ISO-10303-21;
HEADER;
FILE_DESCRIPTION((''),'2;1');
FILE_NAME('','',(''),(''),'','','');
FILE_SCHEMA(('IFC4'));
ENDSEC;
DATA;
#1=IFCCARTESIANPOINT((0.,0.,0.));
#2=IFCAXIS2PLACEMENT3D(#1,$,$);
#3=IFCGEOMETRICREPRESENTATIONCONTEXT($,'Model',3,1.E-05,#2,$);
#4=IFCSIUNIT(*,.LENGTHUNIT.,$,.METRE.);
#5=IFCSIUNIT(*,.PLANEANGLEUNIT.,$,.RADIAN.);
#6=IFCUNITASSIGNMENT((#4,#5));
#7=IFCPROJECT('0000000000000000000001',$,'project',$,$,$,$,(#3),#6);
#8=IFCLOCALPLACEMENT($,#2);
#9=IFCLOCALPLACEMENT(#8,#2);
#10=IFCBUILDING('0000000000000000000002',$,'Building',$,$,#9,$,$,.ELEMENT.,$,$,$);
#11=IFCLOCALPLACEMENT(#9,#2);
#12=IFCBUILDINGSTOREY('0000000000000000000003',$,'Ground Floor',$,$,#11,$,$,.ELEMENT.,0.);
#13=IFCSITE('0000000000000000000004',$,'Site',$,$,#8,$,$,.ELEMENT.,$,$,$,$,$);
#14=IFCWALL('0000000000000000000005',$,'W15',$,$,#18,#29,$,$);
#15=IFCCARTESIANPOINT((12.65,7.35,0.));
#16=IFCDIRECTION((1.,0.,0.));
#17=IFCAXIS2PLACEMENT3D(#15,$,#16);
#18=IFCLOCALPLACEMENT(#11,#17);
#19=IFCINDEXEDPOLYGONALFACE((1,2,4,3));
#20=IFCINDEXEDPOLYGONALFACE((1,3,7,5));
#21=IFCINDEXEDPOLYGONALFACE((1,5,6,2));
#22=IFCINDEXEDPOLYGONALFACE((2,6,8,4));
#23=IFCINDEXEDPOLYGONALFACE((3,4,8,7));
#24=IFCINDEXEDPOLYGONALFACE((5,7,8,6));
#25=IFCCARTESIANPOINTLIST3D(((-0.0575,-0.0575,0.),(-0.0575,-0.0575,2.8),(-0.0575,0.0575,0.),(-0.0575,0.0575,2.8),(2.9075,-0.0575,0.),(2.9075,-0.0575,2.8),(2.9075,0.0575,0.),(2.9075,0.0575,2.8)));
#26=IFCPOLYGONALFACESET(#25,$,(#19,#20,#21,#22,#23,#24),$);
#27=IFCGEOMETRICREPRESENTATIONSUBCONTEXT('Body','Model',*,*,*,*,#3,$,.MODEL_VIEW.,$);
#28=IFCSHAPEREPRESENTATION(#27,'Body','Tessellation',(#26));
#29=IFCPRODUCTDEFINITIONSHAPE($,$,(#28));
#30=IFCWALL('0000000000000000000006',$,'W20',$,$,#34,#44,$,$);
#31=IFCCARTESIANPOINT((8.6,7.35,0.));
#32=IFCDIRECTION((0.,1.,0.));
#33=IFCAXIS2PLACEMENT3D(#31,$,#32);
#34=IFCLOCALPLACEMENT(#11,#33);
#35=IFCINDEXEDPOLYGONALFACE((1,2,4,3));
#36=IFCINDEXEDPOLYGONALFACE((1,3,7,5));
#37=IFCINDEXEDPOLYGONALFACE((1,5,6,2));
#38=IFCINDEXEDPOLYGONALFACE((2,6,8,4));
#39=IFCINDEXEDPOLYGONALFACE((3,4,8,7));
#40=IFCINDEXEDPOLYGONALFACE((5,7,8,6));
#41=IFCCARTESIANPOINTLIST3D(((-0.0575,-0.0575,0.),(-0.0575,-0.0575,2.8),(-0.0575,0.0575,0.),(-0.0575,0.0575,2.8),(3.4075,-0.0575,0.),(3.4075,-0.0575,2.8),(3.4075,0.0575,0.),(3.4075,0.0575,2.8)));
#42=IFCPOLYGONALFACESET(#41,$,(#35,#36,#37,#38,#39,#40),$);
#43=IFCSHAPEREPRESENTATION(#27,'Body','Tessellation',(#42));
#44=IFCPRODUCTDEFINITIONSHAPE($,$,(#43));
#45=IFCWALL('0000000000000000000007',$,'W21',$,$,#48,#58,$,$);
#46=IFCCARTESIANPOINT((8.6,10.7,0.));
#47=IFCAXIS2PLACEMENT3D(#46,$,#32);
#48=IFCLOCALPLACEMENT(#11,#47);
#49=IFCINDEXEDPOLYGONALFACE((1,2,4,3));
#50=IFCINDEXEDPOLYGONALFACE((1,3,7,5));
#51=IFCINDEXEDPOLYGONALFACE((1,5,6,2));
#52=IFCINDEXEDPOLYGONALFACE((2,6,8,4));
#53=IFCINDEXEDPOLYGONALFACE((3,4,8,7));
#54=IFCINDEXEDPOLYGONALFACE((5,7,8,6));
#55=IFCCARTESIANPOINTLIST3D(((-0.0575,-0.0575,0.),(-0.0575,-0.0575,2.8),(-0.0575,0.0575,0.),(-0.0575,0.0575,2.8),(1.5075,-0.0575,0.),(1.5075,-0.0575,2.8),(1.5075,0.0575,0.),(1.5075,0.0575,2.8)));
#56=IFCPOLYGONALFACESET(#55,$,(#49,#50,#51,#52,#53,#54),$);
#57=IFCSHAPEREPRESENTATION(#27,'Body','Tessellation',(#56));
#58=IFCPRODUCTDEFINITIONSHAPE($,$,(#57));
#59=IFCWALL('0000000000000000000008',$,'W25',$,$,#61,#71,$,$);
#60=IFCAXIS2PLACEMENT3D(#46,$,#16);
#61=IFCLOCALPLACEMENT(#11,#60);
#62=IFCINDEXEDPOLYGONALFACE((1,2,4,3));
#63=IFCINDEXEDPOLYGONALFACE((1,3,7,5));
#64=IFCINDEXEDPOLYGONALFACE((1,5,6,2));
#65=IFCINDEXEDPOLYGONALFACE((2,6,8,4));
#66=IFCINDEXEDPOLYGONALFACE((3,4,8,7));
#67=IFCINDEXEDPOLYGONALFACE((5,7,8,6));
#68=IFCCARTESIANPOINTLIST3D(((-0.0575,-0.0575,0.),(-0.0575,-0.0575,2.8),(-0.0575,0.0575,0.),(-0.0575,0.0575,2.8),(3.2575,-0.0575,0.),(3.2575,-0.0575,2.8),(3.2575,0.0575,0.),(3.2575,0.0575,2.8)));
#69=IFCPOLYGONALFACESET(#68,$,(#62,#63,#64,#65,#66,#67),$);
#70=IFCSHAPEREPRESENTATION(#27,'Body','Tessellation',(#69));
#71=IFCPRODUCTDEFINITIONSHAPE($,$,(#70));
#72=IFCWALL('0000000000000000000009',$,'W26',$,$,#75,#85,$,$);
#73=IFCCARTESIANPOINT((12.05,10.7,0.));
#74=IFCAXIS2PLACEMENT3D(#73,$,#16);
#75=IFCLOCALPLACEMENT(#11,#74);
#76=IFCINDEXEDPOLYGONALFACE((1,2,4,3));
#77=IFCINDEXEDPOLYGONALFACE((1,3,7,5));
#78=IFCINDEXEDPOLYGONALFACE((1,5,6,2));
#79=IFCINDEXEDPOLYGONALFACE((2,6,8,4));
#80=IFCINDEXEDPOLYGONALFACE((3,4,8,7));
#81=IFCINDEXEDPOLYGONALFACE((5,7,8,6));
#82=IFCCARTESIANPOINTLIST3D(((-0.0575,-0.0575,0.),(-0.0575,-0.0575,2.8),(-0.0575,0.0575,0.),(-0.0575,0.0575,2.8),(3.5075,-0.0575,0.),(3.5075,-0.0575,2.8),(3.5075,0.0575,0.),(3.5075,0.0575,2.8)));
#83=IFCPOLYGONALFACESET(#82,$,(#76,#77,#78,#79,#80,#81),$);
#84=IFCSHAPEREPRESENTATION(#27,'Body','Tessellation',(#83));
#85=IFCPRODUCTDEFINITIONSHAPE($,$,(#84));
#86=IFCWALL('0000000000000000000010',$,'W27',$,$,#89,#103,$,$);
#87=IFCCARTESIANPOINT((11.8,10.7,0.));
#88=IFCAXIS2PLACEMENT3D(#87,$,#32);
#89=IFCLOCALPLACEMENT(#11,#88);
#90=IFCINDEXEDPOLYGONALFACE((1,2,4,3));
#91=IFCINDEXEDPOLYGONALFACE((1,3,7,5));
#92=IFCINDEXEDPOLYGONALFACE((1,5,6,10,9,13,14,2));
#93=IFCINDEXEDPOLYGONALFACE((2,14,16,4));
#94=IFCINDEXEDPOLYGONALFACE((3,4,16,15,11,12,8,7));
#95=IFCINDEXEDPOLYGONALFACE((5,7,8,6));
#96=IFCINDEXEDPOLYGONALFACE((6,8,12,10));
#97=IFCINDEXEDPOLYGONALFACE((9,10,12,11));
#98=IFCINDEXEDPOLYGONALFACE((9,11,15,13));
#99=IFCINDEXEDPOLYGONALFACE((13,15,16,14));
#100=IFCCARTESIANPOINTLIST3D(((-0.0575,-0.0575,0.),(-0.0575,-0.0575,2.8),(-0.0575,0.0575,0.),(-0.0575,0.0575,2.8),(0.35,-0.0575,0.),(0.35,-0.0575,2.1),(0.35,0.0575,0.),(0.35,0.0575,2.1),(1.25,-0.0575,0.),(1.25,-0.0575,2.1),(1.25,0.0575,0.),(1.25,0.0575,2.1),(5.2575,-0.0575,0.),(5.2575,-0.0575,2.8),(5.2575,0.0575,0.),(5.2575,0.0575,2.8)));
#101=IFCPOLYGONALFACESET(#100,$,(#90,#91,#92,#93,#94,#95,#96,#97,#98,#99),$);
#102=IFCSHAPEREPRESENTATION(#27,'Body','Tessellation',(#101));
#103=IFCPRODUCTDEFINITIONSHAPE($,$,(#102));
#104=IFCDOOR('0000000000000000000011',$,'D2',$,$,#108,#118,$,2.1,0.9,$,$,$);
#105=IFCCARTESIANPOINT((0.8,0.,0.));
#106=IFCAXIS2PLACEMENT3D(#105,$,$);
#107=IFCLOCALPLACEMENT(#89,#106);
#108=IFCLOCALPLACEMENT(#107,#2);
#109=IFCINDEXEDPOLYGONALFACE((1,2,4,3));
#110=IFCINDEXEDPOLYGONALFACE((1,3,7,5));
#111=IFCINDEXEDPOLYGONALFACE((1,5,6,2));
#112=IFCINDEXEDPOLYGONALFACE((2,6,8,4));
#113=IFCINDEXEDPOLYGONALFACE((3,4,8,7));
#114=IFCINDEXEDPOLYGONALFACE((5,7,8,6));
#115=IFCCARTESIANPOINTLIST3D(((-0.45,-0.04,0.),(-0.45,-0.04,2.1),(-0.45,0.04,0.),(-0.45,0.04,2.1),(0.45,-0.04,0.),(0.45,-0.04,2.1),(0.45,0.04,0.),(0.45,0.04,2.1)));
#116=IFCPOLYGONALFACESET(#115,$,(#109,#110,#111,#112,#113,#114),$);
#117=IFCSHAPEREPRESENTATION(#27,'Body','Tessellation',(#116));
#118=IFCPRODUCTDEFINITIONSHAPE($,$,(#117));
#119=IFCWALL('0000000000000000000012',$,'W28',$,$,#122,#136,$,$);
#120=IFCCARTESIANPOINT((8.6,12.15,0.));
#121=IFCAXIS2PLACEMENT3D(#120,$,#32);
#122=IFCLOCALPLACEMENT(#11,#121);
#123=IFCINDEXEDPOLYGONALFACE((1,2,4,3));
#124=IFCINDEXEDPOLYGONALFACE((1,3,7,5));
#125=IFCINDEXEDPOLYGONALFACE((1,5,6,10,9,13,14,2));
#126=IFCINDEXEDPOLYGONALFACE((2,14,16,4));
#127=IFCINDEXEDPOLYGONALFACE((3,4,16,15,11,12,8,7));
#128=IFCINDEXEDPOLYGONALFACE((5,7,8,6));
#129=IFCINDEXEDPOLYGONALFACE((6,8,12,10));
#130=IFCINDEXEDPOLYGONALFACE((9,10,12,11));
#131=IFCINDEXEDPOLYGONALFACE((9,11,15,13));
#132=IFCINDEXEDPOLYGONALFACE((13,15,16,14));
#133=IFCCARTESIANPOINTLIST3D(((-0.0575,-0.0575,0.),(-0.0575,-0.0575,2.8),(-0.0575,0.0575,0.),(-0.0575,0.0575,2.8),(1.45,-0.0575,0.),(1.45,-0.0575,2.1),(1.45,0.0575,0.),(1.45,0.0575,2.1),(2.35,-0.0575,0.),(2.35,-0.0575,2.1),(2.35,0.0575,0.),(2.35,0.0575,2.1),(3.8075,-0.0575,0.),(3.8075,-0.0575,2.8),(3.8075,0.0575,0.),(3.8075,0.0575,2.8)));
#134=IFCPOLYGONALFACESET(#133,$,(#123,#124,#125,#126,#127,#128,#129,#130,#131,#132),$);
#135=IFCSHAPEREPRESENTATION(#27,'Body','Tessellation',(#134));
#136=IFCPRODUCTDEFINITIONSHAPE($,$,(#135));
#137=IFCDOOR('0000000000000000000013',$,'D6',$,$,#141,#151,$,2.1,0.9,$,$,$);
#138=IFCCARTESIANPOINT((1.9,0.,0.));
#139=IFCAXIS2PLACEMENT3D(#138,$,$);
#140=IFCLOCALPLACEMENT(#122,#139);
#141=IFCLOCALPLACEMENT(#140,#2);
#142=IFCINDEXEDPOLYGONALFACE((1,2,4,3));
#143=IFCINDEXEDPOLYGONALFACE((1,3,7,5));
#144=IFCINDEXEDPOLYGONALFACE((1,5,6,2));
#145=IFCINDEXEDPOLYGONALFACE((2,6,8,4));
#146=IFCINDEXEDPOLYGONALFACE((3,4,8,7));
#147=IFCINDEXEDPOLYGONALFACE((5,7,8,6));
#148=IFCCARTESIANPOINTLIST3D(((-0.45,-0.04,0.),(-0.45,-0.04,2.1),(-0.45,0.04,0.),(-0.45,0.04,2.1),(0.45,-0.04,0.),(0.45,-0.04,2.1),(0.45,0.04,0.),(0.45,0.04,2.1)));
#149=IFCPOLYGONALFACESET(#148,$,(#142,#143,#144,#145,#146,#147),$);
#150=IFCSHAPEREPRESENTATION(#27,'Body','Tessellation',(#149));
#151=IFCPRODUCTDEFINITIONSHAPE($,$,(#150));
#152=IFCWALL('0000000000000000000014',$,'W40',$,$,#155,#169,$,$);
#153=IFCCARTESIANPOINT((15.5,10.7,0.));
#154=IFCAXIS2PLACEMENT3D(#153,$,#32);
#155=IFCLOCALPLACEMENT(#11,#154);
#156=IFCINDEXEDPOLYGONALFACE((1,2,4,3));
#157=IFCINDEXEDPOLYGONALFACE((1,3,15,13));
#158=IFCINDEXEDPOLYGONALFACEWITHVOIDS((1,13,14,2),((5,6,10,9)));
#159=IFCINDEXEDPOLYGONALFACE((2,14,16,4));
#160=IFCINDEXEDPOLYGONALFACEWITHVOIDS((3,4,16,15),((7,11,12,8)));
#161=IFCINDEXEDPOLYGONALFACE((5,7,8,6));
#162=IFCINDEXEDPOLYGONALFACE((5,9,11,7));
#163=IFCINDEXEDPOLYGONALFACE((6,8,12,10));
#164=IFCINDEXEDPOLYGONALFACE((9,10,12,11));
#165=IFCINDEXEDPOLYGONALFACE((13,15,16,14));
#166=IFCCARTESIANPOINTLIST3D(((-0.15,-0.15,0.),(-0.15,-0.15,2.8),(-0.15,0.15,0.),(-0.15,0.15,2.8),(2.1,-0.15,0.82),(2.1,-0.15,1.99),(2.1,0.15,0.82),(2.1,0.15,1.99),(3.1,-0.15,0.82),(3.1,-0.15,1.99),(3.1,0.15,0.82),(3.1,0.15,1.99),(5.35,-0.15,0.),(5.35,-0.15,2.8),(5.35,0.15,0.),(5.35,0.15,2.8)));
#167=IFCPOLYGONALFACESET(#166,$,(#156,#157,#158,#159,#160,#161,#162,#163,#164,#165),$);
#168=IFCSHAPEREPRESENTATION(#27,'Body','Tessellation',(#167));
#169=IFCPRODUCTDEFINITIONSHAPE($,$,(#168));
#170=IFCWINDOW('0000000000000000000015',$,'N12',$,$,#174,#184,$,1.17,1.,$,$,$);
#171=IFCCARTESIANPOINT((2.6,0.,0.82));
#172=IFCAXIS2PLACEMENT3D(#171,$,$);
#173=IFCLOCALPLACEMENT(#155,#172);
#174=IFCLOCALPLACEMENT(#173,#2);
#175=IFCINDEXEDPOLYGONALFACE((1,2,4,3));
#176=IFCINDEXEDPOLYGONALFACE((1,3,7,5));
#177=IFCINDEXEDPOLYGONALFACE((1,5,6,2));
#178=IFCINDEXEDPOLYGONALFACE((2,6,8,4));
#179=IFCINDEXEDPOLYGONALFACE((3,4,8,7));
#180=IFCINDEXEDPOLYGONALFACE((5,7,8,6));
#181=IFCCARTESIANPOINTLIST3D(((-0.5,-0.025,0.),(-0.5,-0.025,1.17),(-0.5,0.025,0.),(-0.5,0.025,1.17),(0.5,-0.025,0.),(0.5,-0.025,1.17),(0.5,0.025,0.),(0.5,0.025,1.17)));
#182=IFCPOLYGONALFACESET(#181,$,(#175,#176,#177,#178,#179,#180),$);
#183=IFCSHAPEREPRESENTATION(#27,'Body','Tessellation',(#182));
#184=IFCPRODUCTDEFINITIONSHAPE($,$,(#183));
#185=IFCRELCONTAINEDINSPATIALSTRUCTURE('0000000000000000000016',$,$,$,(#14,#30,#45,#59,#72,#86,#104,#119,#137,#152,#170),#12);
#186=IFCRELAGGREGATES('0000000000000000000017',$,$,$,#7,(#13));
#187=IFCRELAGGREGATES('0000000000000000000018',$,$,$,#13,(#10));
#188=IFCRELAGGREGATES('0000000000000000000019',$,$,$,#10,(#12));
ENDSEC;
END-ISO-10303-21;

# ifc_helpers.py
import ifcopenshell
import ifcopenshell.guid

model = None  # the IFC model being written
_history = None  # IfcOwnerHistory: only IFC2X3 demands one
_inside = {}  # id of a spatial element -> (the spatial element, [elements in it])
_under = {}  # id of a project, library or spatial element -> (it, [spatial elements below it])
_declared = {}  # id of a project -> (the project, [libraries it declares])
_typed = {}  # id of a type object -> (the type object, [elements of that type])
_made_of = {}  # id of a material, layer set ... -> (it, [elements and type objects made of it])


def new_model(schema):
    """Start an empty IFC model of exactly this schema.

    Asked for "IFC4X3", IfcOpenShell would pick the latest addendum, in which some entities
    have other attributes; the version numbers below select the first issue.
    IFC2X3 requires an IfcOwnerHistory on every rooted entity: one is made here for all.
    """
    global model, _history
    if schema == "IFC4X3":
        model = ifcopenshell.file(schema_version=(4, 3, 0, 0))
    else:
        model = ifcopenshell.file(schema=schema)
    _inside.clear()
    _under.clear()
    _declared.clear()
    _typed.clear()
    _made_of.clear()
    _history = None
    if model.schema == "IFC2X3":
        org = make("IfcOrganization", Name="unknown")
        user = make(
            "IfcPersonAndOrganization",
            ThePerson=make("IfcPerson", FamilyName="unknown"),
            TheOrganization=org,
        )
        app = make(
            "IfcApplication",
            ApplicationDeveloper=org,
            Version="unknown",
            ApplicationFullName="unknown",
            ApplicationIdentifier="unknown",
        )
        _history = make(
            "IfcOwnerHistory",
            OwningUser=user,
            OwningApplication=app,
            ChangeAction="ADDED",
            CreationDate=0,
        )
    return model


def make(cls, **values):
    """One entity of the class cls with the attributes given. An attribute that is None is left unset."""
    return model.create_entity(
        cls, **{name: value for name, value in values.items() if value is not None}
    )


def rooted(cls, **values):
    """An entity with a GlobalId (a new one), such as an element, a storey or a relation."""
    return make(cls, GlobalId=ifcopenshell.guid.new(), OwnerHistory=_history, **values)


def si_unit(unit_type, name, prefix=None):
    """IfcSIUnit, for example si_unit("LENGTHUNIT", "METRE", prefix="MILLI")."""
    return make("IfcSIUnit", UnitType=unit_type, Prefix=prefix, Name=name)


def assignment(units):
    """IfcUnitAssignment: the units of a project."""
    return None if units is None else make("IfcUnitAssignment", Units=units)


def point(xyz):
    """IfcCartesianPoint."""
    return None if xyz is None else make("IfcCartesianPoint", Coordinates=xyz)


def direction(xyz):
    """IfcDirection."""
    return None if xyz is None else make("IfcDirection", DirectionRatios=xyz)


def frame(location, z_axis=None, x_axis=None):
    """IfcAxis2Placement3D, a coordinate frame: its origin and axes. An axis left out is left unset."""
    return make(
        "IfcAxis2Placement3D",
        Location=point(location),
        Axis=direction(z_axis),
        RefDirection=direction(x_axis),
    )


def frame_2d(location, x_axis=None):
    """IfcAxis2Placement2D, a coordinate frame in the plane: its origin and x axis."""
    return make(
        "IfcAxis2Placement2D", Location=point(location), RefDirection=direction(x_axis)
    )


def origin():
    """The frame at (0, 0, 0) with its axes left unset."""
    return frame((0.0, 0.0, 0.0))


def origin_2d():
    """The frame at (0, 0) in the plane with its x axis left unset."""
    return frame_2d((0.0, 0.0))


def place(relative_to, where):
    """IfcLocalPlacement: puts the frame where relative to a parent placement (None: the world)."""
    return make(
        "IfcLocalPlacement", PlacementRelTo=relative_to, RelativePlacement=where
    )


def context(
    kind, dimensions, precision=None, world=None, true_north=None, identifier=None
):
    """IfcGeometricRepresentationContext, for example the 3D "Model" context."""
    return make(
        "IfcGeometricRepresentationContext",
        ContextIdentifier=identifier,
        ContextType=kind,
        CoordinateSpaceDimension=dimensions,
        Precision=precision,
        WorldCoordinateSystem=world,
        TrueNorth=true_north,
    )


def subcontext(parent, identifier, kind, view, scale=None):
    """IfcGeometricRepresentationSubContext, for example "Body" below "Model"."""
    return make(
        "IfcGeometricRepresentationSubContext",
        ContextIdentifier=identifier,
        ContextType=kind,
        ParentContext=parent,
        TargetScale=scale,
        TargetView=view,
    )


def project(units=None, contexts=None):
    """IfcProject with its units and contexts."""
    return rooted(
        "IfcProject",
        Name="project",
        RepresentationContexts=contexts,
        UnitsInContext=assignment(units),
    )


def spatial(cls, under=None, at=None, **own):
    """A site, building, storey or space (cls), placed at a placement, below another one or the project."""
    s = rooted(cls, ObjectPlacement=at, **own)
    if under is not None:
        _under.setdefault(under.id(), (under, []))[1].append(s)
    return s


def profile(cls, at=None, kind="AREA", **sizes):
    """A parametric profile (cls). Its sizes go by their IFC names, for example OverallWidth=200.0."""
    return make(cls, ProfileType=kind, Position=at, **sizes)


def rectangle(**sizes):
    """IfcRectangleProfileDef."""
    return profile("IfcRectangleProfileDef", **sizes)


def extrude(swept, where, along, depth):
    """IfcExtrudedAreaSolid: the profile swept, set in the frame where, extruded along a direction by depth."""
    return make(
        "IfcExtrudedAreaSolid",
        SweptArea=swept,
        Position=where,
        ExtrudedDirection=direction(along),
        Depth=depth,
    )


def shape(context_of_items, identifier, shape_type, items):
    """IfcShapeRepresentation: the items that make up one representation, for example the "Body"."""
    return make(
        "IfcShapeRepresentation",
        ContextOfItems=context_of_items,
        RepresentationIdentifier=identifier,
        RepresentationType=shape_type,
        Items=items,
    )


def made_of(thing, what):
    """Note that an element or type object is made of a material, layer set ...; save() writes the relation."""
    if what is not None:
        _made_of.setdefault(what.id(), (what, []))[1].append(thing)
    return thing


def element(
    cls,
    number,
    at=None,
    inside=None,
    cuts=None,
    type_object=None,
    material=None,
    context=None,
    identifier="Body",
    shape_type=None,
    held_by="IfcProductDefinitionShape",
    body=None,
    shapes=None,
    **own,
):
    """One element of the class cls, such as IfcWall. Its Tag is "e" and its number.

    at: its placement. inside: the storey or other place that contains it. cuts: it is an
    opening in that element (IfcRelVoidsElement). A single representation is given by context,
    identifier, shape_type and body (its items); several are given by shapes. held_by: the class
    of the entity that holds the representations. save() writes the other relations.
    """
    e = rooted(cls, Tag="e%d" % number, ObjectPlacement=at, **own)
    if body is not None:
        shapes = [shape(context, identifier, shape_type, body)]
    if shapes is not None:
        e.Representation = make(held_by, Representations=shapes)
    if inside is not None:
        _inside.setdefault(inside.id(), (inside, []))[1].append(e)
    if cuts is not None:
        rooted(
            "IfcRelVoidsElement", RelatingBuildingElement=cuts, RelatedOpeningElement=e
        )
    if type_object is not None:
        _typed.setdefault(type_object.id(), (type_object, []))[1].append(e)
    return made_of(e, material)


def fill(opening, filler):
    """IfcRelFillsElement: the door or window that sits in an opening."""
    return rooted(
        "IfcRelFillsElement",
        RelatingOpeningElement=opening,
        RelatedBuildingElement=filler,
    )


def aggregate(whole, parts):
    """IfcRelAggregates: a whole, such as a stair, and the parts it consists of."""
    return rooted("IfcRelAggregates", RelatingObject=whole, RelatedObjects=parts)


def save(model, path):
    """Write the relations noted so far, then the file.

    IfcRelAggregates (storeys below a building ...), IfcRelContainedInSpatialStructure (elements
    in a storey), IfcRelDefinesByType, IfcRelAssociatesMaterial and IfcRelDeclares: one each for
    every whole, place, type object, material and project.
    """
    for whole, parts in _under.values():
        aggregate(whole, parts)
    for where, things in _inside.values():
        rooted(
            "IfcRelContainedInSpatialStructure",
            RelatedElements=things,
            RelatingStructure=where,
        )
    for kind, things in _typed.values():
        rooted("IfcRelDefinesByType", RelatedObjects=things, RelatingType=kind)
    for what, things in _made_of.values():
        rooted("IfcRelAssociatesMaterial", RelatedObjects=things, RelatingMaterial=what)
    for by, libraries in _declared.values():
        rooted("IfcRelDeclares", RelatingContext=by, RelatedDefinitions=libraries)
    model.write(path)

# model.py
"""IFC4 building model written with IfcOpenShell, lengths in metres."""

from ifc_helpers import new_model, si_unit, frame, frame_2d, origin, origin_2d, place, context, subcontext, project, spatial, rectangle, extrude, element, fill, save


model = new_model("IFC4")

# Units and contexts
model_context = context("Model", 3, precision=1e-05, world=origin())
body_context = subcontext(model_context, "Body", "Model", "MODEL_VIEW")
ifc_project = project(units=[si_unit("LENGTHUNIT", "METRE"), si_unit("PLANEANGLEUNIT", "RADIAN")], contexts=[model_context])

# Site, building, storey
site_placement = place(None, origin())
site = spatial("IfcSite", under=ifc_project, at=site_placement, Name="Site", CompositionType="ELEMENT")
building_placement = place(site_placement, origin())
building = spatial("IfcBuilding", under=site, at=building_placement, Name="Building", CompositionType="ELEMENT")
storey_placement = place(building_placement, origin())
storey = spatial("IfcBuildingStorey", under=building, at=storey_placement, Name="Ground Floor", CompositionType="ELEMENT", Elevation=0.0)

# Walls
wall_1_placement = place(storey_placement, frame((12.65, 7.35, 0.0), x_axis=(1.0, 0.0, 0.0)))
element("IfcWall", 1, at=wall_1_placement, inside=storey, Name="W15", context=body_context, shape_type="SweptSolid", body=[
    extrude(rectangle(XDim=2.965, YDim=0.115, at=frame_2d((1.425, 0.0))), origin(), (0.0, 0.0, 1.0), 2.8),
])
wall_2_placement = place(storey_placement, frame((8.6, 7.35, 0.0), x_axis=(0.0, 1.0, 0.0)))
element("IfcWall", 2, at=wall_2_placement, inside=storey, Name="W20", context=body_context, shape_type="SweptSolid", body=[
    extrude(rectangle(XDim=3.465, YDim=0.115, at=frame_2d((1.675, 0.0))), origin(), (0.0, 0.0, 1.0), 2.8),
])
wall_3_placement = place(storey_placement, frame((8.6, 10.7, 0.0), x_axis=(0.0, 1.0, 0.0)))
element("IfcWall", 3, at=wall_3_placement, inside=storey, Name="W21", context=body_context, shape_type="SweptSolid", body=[
    extrude(rectangle(XDim=1.565, YDim=0.115, at=frame_2d((0.725, 0.0))), origin(), (0.0, 0.0, 1.0), 2.8),
])

# Walls
wall_4_placement = place(storey_placement, frame((8.6, 10.7, 0.0), x_axis=(1.0, 0.0, 0.0)))
element("IfcWall", 4, at=wall_4_placement, inside=storey, Name="W25", context=body_context, shape_type="SweptSolid", body=[
    extrude(rectangle(XDim=3.315, YDim=0.115, at=frame_2d((1.6, 0.0))), origin(), (0.0, 0.0, 1.0), 2.8),
])
wall_5_placement = place(storey_placement, frame((12.05, 10.7, 0.0), x_axis=(1.0, 0.0, 0.0)))
element("IfcWall", 5, at=wall_5_placement, inside=storey, Name="W26", context=body_context, shape_type="SweptSolid", body=[
    extrude(rectangle(XDim=3.565, YDim=0.115, at=frame_2d((1.725, 0.0))), origin(), (0.0, 0.0, 1.0), 2.8),
])

# Walls, openings, doors
wall_6_placement = place(storey_placement, frame((11.8, 10.7, 0.0), x_axis=(0.0, 1.0, 0.0)))
wall_6 = element("IfcWall", 6, at=wall_6_placement, inside=storey, Name="W27", context=body_context, shape_type="SweptSolid", body=[
    extrude(rectangle(XDim=5.315, YDim=0.115, at=frame_2d((2.6, 0.0))), origin(), (0.0, 0.0, 1.0), 2.8),
])
opening_1_placement = place(wall_6_placement, frame((0.8, 0.0, 0.0)))
opening_1 = element("IfcOpeningElement", 7, at=opening_1_placement, cuts=wall_6, context=body_context, shape_type="SweptSolid", body=[
    extrude(rectangle(XDim=0.9, YDim=0.215, at=origin_2d()), origin(), (0.0, 0.0, 1.0), 2.1),
])
door_1_placement = place(opening_1_placement, origin())
door_1 = element("IfcDoor", 8, at=door_1_placement, inside=storey, Name="D2", OverallHeight=2.1, OverallWidth=0.9, context=body_context, shape_type="SweptSolid", body=[
    extrude(rectangle(XDim=0.9, YDim=0.08, at=origin_2d()), origin(), (0.0, 0.0, 1.0), 2.1),
])
fill(opening_1, door_1)
wall_7_placement = place(storey_placement, frame((8.6, 12.15, 0.0), x_axis=(0.0, 1.0, 0.0)))
wall_7 = element("IfcWall", 9, at=wall_7_placement, inside=storey, Name="W28", context=body_context, shape_type="SweptSolid", body=[
    extrude(rectangle(XDim=3.865, YDim=0.115, at=frame_2d((1.875, 0.0))), origin(), (0.0, 0.0, 1.0), 2.8),
])
opening_2_placement = place(wall_7_placement, frame((1.9, 0.0, 0.0)))
opening_2 = element("IfcOpeningElement", 10, at=opening_2_placement, cuts=wall_7, context=body_context, shape_type="SweptSolid", body=[
    extrude(rectangle(XDim=0.9, YDim=0.215, at=origin_2d()), origin(), (0.0, 0.0, 1.0), 2.1),
])
door_2_placement = place(opening_2_placement, origin())
door_2 = element("IfcDoor", 11, at=door_2_placement, inside=storey, Name="D6", OverallHeight=2.1, OverallWidth=0.9, context=body_context, shape_type="SweptSolid", body=[
    extrude(rectangle(XDim=0.9, YDim=0.08, at=origin_2d()), origin(), (0.0, 0.0, 1.0), 2.1),
])
fill(opening_2, door_2)

# Wall, opening, window
wall_8_placement = place(storey_placement, frame((15.5, 10.7, 0.0), x_axis=(0.0, 1.0, 0.0)))
wall_8 = element("IfcWall", 12, at=wall_8_placement, inside=storey, Name="W40", context=body_context, shape_type="SweptSolid", body=[
    extrude(rectangle(XDim=5.5, YDim=0.3, at=frame_2d((2.6, 0.0))), origin(), (0.0, 0.0, 1.0), 2.8),
])
opening_3_placement = place(wall_8_placement, frame((2.6, 0.0, 0.82)))
opening_3 = element("IfcOpeningElement", 13, at=opening_3_placement, cuts=wall_8, context=body_context, shape_type="SweptSolid", body=[
    extrude(rectangle(XDim=1.0, YDim=0.4, at=origin_2d()), origin(), (0.0, 0.0, 1.0), 1.17),
])
window_1_placement = place(opening_3_placement, origin())
window_1 = element("IfcWindow", 14, at=window_1_placement, inside=storey, Name="N12", OverallHeight=1.17, OverallWidth=1.0, context=body_context, shape_type="SweptSolid", body=[
    extrude(rectangle(XDim=1.0, YDim=0.05, at=origin_2d()), origin(), (0.0, 0.0, 1.0), 1.17),
])
fill(opening_3, window_1)

save(model, "model.ifc")
